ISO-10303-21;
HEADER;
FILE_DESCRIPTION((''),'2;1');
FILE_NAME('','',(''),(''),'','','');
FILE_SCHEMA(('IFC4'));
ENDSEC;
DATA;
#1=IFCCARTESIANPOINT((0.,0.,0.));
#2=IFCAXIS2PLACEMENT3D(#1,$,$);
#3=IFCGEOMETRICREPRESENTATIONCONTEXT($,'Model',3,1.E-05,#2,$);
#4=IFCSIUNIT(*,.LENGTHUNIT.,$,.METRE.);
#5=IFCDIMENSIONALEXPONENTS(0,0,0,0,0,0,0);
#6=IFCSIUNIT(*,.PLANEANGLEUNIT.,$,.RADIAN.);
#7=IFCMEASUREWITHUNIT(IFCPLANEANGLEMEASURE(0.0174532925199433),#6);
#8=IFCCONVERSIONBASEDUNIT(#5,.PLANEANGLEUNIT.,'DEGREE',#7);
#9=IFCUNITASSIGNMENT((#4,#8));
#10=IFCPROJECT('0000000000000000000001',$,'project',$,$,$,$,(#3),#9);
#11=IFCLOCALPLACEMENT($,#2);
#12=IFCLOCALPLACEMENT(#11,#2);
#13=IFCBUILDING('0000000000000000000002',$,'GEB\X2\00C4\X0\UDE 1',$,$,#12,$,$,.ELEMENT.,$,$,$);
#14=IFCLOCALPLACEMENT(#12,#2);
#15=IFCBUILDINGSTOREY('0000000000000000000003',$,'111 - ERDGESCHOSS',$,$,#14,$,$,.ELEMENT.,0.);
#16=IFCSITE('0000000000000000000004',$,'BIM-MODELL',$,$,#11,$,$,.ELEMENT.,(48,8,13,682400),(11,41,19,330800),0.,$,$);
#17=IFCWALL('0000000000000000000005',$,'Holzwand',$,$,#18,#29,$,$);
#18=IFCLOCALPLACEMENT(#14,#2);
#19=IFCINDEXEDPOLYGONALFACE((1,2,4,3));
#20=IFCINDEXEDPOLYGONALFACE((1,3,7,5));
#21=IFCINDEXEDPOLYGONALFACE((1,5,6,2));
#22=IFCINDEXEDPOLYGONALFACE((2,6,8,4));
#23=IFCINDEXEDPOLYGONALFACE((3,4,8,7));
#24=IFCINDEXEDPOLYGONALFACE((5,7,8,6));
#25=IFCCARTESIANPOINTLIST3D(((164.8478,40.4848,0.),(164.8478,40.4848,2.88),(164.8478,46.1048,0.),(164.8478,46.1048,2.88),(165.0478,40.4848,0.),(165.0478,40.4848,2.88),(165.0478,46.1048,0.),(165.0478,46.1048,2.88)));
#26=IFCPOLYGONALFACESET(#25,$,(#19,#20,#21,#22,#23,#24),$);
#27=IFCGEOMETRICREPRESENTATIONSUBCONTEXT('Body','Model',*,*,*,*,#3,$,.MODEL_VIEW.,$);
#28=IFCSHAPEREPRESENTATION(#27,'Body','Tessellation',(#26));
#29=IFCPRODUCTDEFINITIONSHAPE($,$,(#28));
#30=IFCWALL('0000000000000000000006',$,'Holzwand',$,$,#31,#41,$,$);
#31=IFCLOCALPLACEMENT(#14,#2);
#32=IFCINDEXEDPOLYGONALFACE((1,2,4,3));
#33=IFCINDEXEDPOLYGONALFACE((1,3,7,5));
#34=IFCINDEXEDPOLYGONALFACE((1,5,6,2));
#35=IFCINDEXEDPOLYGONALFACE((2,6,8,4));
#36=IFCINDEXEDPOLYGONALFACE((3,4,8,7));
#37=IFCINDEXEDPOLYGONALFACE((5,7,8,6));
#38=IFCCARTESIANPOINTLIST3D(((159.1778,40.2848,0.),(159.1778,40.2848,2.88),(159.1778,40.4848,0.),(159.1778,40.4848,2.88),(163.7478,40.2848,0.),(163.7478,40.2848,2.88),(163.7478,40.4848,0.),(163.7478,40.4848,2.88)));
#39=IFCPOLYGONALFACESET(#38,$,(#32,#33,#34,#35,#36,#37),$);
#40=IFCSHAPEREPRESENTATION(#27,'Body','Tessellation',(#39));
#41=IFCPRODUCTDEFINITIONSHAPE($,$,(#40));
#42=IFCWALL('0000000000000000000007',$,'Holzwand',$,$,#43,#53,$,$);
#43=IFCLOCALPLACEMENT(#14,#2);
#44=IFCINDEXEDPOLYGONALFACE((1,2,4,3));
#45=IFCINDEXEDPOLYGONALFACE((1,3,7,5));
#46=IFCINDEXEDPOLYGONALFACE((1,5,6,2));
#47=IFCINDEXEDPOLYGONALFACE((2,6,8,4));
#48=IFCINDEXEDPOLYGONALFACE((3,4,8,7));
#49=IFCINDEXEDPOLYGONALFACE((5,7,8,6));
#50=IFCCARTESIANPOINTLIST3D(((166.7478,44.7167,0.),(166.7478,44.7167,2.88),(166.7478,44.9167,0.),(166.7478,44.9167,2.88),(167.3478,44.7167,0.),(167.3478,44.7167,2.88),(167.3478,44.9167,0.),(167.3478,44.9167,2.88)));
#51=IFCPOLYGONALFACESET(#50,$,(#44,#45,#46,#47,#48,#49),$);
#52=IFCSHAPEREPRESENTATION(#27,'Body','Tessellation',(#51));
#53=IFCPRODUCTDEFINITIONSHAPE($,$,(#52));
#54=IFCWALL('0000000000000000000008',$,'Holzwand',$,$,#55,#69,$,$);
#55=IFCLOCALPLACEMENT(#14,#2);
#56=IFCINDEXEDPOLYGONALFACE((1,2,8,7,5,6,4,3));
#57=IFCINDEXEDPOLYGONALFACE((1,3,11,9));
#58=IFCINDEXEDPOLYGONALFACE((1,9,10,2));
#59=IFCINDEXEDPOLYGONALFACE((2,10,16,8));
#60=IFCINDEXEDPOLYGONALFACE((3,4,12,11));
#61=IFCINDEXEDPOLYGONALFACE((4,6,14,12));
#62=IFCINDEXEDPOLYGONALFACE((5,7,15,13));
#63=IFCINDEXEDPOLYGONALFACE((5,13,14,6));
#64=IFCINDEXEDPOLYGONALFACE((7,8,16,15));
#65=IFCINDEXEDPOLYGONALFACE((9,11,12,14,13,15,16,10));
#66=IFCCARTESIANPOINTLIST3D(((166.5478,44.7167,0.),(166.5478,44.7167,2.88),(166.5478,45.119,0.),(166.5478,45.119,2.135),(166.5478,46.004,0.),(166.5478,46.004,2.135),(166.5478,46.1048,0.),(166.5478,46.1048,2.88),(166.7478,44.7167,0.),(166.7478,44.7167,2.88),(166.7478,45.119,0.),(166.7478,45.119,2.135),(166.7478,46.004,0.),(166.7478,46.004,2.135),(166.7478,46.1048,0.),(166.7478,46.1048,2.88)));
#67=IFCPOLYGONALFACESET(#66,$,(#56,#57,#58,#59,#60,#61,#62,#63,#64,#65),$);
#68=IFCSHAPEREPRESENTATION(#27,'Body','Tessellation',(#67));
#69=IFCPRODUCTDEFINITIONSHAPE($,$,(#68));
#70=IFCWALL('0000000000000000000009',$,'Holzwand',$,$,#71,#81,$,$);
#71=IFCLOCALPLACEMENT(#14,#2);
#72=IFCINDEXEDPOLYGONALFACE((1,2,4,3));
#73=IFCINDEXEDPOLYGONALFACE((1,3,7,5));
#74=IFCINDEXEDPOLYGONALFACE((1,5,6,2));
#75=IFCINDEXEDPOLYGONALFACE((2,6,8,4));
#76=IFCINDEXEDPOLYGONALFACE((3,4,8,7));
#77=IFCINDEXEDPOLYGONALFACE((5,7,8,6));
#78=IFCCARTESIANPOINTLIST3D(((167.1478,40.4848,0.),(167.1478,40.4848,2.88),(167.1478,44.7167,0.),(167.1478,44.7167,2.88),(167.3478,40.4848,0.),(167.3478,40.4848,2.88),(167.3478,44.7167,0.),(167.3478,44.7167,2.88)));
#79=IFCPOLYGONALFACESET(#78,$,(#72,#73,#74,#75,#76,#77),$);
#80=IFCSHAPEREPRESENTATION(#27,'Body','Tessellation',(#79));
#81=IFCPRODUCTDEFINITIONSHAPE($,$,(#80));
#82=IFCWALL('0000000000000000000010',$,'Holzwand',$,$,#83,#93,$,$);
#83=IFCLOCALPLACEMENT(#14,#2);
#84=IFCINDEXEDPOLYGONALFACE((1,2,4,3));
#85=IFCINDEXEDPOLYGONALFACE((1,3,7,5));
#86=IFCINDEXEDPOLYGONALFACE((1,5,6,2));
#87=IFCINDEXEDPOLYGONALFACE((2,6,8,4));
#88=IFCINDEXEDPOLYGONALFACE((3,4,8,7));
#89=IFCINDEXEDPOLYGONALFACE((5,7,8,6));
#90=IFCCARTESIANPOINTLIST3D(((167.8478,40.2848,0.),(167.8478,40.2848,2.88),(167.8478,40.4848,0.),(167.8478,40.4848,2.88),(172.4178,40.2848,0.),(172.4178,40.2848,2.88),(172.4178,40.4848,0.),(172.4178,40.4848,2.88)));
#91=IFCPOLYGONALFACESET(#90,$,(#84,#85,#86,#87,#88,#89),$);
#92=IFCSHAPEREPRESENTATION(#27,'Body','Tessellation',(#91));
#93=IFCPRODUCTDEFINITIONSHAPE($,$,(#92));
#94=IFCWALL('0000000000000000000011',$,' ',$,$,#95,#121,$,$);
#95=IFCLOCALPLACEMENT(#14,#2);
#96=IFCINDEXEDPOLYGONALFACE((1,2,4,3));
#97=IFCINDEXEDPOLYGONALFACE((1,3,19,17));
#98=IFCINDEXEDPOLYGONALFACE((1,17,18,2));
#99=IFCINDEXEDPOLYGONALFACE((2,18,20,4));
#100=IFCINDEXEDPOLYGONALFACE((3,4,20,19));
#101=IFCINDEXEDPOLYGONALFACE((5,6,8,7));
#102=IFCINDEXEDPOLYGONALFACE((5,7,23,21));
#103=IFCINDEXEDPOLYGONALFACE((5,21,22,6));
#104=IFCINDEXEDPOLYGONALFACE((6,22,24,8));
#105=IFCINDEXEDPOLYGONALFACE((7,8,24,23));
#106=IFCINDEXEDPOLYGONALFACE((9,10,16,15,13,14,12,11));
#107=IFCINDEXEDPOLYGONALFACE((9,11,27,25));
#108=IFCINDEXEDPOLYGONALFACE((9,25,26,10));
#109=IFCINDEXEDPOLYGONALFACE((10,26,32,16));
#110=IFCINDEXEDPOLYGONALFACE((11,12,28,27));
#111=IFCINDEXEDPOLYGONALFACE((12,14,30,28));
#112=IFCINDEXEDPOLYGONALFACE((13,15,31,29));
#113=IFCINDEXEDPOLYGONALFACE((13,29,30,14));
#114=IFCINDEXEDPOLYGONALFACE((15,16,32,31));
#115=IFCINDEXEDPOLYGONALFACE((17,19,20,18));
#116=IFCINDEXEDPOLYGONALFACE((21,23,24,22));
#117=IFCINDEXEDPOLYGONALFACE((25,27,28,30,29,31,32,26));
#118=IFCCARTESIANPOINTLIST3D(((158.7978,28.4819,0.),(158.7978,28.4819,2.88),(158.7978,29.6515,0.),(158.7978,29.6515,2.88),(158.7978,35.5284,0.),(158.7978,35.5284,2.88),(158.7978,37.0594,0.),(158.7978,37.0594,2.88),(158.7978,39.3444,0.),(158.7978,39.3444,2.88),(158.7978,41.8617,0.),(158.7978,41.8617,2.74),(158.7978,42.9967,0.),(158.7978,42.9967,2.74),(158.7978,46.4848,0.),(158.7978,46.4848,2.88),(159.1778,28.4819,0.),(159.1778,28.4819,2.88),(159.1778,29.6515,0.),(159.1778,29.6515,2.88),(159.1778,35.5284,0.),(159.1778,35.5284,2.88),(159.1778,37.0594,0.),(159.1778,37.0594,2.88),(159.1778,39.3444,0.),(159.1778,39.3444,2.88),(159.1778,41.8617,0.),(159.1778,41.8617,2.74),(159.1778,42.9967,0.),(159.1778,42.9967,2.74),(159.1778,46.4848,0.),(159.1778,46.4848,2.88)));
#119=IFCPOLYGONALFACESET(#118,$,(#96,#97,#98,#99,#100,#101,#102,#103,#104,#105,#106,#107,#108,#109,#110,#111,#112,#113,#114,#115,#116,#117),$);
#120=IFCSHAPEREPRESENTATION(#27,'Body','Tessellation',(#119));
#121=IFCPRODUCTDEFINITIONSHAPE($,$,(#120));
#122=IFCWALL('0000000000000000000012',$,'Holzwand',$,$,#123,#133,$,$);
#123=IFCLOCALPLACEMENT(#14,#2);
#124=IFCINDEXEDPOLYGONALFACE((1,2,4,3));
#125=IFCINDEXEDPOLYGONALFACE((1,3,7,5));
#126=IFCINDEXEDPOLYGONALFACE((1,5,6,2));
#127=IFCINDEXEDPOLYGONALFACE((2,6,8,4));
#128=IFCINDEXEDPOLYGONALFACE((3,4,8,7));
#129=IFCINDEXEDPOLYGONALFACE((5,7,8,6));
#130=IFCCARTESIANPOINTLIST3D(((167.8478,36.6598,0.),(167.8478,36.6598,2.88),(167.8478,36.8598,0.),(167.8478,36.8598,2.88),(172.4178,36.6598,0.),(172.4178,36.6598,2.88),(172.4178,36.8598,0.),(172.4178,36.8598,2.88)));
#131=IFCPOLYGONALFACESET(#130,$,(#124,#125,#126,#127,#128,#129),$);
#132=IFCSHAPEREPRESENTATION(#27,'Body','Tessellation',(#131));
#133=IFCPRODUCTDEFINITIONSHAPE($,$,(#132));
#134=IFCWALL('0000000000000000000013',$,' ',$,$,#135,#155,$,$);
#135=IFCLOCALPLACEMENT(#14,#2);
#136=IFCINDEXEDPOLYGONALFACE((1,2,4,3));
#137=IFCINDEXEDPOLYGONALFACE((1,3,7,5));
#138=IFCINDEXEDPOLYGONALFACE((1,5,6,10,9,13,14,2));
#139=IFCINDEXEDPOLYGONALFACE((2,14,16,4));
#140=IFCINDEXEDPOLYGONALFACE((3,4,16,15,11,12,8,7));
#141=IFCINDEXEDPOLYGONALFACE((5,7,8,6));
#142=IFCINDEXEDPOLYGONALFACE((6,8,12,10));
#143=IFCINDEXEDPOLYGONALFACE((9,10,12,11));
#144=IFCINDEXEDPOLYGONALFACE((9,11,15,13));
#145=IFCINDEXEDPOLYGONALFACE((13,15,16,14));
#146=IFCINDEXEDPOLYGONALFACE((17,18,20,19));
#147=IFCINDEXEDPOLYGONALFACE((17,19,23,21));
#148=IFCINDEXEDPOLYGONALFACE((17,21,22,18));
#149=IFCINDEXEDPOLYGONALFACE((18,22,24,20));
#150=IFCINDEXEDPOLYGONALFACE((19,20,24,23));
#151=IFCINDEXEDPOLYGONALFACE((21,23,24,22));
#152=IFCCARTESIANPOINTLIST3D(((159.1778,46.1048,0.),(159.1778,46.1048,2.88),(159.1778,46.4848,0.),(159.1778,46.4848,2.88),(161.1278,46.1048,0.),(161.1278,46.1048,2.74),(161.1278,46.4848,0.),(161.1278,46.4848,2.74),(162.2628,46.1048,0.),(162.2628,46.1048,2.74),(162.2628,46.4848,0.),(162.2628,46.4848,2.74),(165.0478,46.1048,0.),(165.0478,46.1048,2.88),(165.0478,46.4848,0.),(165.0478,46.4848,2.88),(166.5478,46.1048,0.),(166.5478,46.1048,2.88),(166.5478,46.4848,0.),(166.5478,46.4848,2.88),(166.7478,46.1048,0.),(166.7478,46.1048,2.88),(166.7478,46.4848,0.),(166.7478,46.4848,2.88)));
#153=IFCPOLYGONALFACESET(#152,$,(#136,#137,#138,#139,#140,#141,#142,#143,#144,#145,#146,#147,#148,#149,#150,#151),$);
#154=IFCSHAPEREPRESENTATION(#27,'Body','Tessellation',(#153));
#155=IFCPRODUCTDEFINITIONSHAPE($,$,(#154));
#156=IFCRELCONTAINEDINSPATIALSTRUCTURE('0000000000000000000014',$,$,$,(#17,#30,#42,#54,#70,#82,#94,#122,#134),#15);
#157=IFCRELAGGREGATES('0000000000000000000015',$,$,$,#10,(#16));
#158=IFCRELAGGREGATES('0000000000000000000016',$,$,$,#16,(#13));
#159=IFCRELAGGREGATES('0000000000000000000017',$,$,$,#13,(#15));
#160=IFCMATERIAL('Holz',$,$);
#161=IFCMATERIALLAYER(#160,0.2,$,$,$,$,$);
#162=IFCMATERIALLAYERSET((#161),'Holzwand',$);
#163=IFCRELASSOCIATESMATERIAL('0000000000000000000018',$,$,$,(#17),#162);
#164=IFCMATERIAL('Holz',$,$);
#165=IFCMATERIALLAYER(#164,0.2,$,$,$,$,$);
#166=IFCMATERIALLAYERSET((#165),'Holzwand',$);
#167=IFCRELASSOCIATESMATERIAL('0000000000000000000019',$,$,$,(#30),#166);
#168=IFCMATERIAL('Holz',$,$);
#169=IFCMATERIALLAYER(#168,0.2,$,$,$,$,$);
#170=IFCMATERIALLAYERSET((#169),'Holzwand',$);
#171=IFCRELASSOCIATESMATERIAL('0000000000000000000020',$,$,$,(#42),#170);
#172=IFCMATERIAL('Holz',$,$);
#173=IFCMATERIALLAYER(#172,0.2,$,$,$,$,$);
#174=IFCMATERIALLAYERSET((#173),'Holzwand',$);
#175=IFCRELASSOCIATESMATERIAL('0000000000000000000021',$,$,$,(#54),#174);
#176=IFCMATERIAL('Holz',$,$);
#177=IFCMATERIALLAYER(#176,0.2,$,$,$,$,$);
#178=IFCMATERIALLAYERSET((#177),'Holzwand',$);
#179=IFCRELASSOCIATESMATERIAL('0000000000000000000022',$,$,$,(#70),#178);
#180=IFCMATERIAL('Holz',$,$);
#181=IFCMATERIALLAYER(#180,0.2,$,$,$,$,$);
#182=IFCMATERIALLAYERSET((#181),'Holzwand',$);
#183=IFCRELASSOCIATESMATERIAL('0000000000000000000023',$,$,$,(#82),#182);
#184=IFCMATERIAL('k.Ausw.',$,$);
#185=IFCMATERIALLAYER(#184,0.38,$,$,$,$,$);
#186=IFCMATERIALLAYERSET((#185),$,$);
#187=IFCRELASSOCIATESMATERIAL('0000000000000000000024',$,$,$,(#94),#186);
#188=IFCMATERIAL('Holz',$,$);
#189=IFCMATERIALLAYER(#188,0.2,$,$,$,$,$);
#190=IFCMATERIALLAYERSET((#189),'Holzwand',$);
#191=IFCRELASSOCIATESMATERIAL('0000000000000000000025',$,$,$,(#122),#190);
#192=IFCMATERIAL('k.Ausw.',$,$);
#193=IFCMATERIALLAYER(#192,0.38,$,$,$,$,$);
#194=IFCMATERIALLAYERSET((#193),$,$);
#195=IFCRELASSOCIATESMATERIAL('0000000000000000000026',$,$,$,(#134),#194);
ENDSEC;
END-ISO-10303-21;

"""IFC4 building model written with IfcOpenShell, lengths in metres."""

from ifc_helpers import new_model, entity, si_unit, converted_unit, frame, frame_2d, origin, origin_with_axes, place, context, subcontext, project, spatial, polyline, rectangle, outline, extrude, material, layer, layer_set, layer_usage, element, save


model = new_model("IFC4")

# Units and contexts
model_context = context("Model", 3, precision=1e-05, world=origin())
body_context = subcontext(model_context, "Body", "Model", "MODEL_VIEW")
ifc_project = project(units=[si_unit("LENGTHUNIT", "METRE"), converted_unit("PLANEANGLEUNIT", "DEGREE", entity("IfcPlaneAngleMeasure", 0.0174532925199433), si_unit("PLANEANGLEUNIT", "RADIAN"), dimensions=[0, 0, 0, 0, 0, 0, 0])], contexts=[model_context])

# Site, building, storey
site_placement = place(None, origin())
site = spatial("IfcSite", under=ifc_project, at=site_placement, Name="BIM-MODELL", CompositionType="ELEMENT", RefLatitude=(48, 8, 13, 682400), RefLongitude=(11, 41, 19, 330800), RefElevation=0.0)
building_placement = place(site_placement, origin())
building = spatial("IfcBuilding", under=site, at=building_placement, Name="GEBÄUDE 1", CompositionType="ELEMENT")
storey_placement = place(building_placement, origin())
storey = spatial("IfcBuildingStorey", under=building, at=storey_placement, Name="111 - ERDGESCHOSS", CompositionType="ELEMENT", Elevation=0.0)

# Walls
ifc_material_1 = material(Name="Holz")
ifc_layer_1 = layer(ifc_material_1, 0.2)
ifc_layer_set_1 = layer_set([ifc_layer_1], Name="Holzwand")
ifc_layer_usage_1 = layer_usage(ifc_layer_set_1, "AXIS2", "POSITIVE", 0.0)
wall_1_placement = place(storey_placement, frame((164.8478, 46.1048, 0.0), z_axis=(0.0, 0.0, 1.0), x_axis=(0.0, -1.0, 0.0)))
element("IfcWall", 1, at=wall_1_placement, inside=storey, material=ifc_layer_usage_1, Name="Holzwand", context=body_context, shape_type="SweptSolid", body=[
    extrude(rectangle(XDim=5.62, YDim=0.2, at=frame_2d((2.81, 0.1), x_axis=(1.0, 0.0))), origin_with_axes(), (0.0, 0.0, 1.0), 2.88),
])
ifc_material_2 = material(Name="Holz")
ifc_layer_2 = layer(ifc_material_2, 0.2)
ifc_layer_set_2 = layer_set([ifc_layer_2], Name="Holzwand")
ifc_layer_usage_2 = layer_usage(ifc_layer_set_2, "AXIS2", "POSITIVE", 0.0)
wall_2_placement = place(storey_placement, frame((163.7478, 40.4848, 0.0), z_axis=(0.0, 0.0, 1.0), x_axis=(-1.0, 0.0, 0.0)))
element("IfcWall", 2, at=wall_2_placement, inside=storey, material=ifc_layer_usage_2, Name="Holzwand", context=body_context, shape_type="SweptSolid", body=[
    extrude(rectangle(XDim=4.57, YDim=0.2, at=frame_2d((2.285, 0.1), x_axis=(1.0, 0.0))), origin_with_axes(), (0.0, 0.0, 1.0), 2.88),
])
ifc_material_3 = material(Name="Holz")
ifc_layer_3 = layer(ifc_material_3, 0.2)
ifc_layer_set_3 = layer_set([ifc_layer_3], Name="Holzwand")
ifc_layer_usage_3 = layer_usage(ifc_layer_set_3, "AXIS2", "POSITIVE", 0.0)
wall_3_placement = place(storey_placement, frame((166.7478, 44.7167, 0.0)))
element("IfcWall", 3, at=wall_3_placement, inside=storey, material=ifc_layer_usage_3, Name="Holzwand", context=body_context, shape_type="SweptSolid", body=[
    extrude(rectangle(XDim=0.6, YDim=0.2, at=frame_2d((0.3, 0.1), x_axis=(1.0, 0.0))), origin_with_axes(), (0.0, 0.0, 1.0), 2.88),
])

# Wall, opening
ifc_material_4 = material(Name="Holz")
ifc_layer_4 = layer(ifc_material_4, 0.2)
ifc_layer_set_4 = layer_set([ifc_layer_4], Name="Holzwand")
ifc_layer_usage_4 = layer_usage(ifc_layer_set_4, "AXIS2", "POSITIVE", 0.0)
wall_4_placement = place(storey_placement, frame((166.5478, 46.1048, 0.0), z_axis=(0.0, 0.0, 1.0), x_axis=(0.0, -1.0, 0.0)))
wall_4 = element("IfcWall", 4, at=wall_4_placement, inside=storey, material=ifc_layer_usage_4, Name="Holzwand", context=body_context, shape_type="SweptSolid", body=[
    extrude(rectangle(XDim=1.3881, YDim=0.2, at=frame_2d((0.6941, 0.1), x_axis=(1.0, 0.0))), origin_with_axes(), (0.0, 0.0, 1.0), 2.88),
])
opening_1_placement = place(wall_4_placement, frame((0.9858, 0.2, 0.0), z_axis=(0.0, -1.0, 0.0), x_axis=(0.0, 0.0, 1.0)))
element("IfcOpeningElement", 5, at=opening_1_placement, cuts=wall_4, ObjectType="Opening", context=body_context, shape_type="SweptSolid", body=[
    extrude(outline(polyline([(0.0, 0.885), (2.135, 0.885), (2.135, 0.0), (0.0, 0.0), (0.0, 0.885)])), origin_with_axes(), (0.0, 0.0, 1.0), 0.2),
])

# Walls
ifc_material_5 = material(Name="Holz")
ifc_layer_5 = layer(ifc_material_5, 0.2)
ifc_layer_set_5 = layer_set([ifc_layer_5], Name="Holzwand")
ifc_layer_usage_5 = layer_usage(ifc_layer_set_5, "AXIS2", "POSITIVE", 0.0)
wall_5_placement = place(storey_placement, frame((167.1478, 44.7167, 0.0), z_axis=(0.0, 0.0, 1.0), x_axis=(0.0, -1.0, 0.0)))
element("IfcWall", 6, at=wall_5_placement, inside=storey, material=ifc_layer_usage_5, Name="Holzwand", context=body_context, shape_type="SweptSolid", body=[
    extrude(rectangle(XDim=4.2319, YDim=0.2, at=frame_2d((2.1159, 0.1), x_axis=(1.0, 0.0))), origin_with_axes(), (0.0, 0.0, 1.0), 2.88),
])
ifc_material_6 = material(Name="Holz")
ifc_layer_6 = layer(ifc_material_6, 0.2)
ifc_layer_set_6 = layer_set([ifc_layer_6], Name="Holzwand")
ifc_layer_usage_6 = layer_usage(ifc_layer_set_6, "AXIS2", "POSITIVE", 0.0)
wall_6_placement = place(storey_placement, frame((172.4178, 40.4848, 0.0), z_axis=(0.0, 0.0, 1.0), x_axis=(-1.0, 0.0, 0.0)))
element("IfcWall", 7, at=wall_6_placement, inside=storey, material=ifc_layer_usage_6, Name="Holzwand", context=body_context, shape_type="SweptSolid", body=[
    extrude(rectangle(XDim=4.57, YDim=0.2, at=frame_2d((2.285, 0.1), x_axis=(1.0, 0.0))), origin_with_axes(), (0.0, 0.0, 1.0), 2.88),
])

# Wall, openings
ifc_material_7 = material(Name="k.Ausw.")
ifc_layer_7 = layer(ifc_material_7, 0.38)
ifc_layer_set_7 = layer_set([ifc_layer_7])
ifc_layer_usage_7 = layer_usage(ifc_layer_set_7, "AXIS2", "POSITIVE", 0.0)
wall_7_placement = place(storey_placement, frame((158.7978, 46.4848, 0.0), z_axis=(0.0, 0.0, 1.0), x_axis=(0.0, -1.0, 0.0)))
wall_7 = element("IfcWall", 8, at=wall_7_placement, inside=storey, material=ifc_layer_usage_7, Name=" ", context=body_context, shape_type="SweptSolid", body=[
    extrude(rectangle(XDim=18.0029, YDim=0.38, at=frame_2d((9.0014, 0.19), x_axis=(1.0, 0.0))), origin_with_axes(), (0.0, 0.0, 1.0), 2.88),
])
opening_2_placement = place(wall_7_placement, frame((8.2904, 0.0, 0.0), z_axis=(0.0, 1.0, 0.0), x_axis=(0.0, 0.0, 1.0)))
element("IfcOpeningElement", 9, at=opening_2_placement, cuts=wall_7, ObjectType="Opening", context=body_context, shape_type="SweptSolid", body=[
    extrude(outline(polyline([(0.0, 1.135), (2.88, 1.135), (2.88, 0.0), (0.0, 0.0), (0.0, 1.135)])), origin_with_axes(), (0.0, 0.0, 1.0), 0.38),
])
opening_3_placement = place(wall_7_placement, frame((10.9564, 0.0, 0.0), z_axis=(0.0, 1.0, 0.0), x_axis=(0.0, 0.0, 1.0)))
element("IfcOpeningElement", 10, at=opening_3_placement, cuts=wall_7, ObjectType="Opening", context=body_context, shape_type="SweptSolid", body=[
    extrude(outline(polyline([(0.0, 1.135), (2.88, 1.135), (2.88, 0.0), (0.0, 0.0), (0.0, 1.135)])), origin_with_axes(), (0.0, 0.0, 1.0), 0.38),
])
opening_4_placement = place(wall_7_placement, frame((15.6983, 0.0, 0.0), z_axis=(0.0, 1.0, 0.0), x_axis=(0.0, 0.0, 1.0)))
element("IfcOpeningElement", 11, at=opening_4_placement, cuts=wall_7, ObjectType="Opening", context=body_context, shape_type="SweptSolid", body=[
    extrude(outline(polyline([(0.0, 1.135), (2.88, 1.135), (2.88, 0.0), (0.0, 0.0), (0.0, 1.135)])), origin_with_axes(), (0.0, 0.0, 1.0), 0.38),
])
opening_5_placement = place(wall_7_placement, frame((12.0914, 0.0, 0.0), z_axis=(0.0, 1.0, 0.0), x_axis=(0.0, 0.0, 1.0)))
element("IfcOpeningElement", 12, at=opening_5_placement, cuts=wall_7, ObjectType="Opening", context=body_context, shape_type="SweptSolid", body=[
    extrude(outline(polyline([(0.0, 3.608), (2.88, 3.608), (2.88, 0.0), (0.0, 0.0), (0.0, 3.608)])), origin_with_axes(), (0.0, 0.0, 1.0), 0.38),
])
opening_6_placement = place(wall_7_placement, frame((7.1404, 0.0, 0.0), z_axis=(0.0, 1.0, 0.0), x_axis=(0.0, 0.0, 1.0)))
element("IfcOpeningElement", 13, at=opening_6_placement, cuts=wall_7, ObjectType="Opening", context=body_context, shape_type="SweptSolid", body=[
    extrude(outline(polyline([(0.0, 1.15), (2.88, 1.15), (2.88, 0.0), (0.0, 0.0), (0.0, 1.15)])), origin_with_axes(), (0.0, 0.0, 1.0), 0.38),
])
opening_7_placement = place(wall_7_placement, frame((3.4881, 0.0, 0.0), z_axis=(0.0, 1.0, 0.0), x_axis=(0.0, 0.0, 1.0)))
element("IfcOpeningElement", 14, at=opening_7_placement, cuts=wall_7, ObjectType="Opening", context=body_context, shape_type="SweptSolid", body=[
    extrude(outline(polyline([(0.0, 1.135), (2.74, 1.135), (2.74, 0.0), (0.0, 0.0), (0.0, 1.135)])), origin_with_axes(), (0.0, 0.0, 1.0), 0.38),
])

# Wall
ifc_material_8 = material(Name="Holz")
ifc_layer_8 = layer(ifc_material_8, 0.2)
ifc_layer_set_8 = layer_set([ifc_layer_8], Name="Holzwand")
ifc_layer_usage_8 = layer_usage(ifc_layer_set_8, "AXIS2", "POSITIVE", 0.0)
wall_8_placement = place(storey_placement, frame((167.8478, 36.6598, 0.0)))
element("IfcWall", 15, at=wall_8_placement, inside=storey, material=ifc_layer_usage_8, Name="Holzwand", context=body_context, shape_type="SweptSolid", body=[
    extrude(rectangle(XDim=4.57, YDim=0.2, at=frame_2d((2.285, 0.1), x_axis=(1.0, 0.0))), origin_with_axes(), (0.0, 0.0, 1.0), 2.88),
])

# Wall, openings
ifc_material_9 = material(Name="k.Ausw.")
ifc_layer_9 = layer(ifc_material_9, 0.38)
ifc_layer_set_9 = layer_set([ifc_layer_9])
ifc_layer_usage_9 = layer_usage(ifc_layer_set_9, "AXIS2", "POSITIVE", 0.0)
wall_9_placement = place(storey_placement, frame((166.7478, 46.4848, 0.0), z_axis=(0.0, 0.0, 1.0), x_axis=(-1.0, 0.0, 0.0)))
wall_9 = element("IfcWall", 16, at=wall_9_placement, inside=storey, material=ifc_layer_usage_9, Name=" ", context=body_context, shape_type="SweptSolid", body=[
    extrude(rectangle(XDim=7.57, YDim=0.38, at=frame_2d((3.785, 0.19), x_axis=(1.0, 0.0))), origin_with_axes(), (0.0, 0.0, 1.0), 2.88),
])
opening_8_placement = place(wall_9_placement, frame((5.62, 0.38, 0.0), z_axis=(0.0, -1.0, 0.0), x_axis=(0.0, 0.0, 1.0)))
element("IfcOpeningElement", 17, at=opening_8_placement, cuts=wall_9, ObjectType="Opening", context=body_context, shape_type="SweptSolid", body=[
    extrude(outline(polyline([(0.0, 1.135), (2.74, 1.135), (2.74, 0.0), (0.0, 0.0), (0.0, 1.135)])), origin_with_axes(), (0.0, 0.0, 1.0), 0.38),
])
opening_9_placement = place(wall_9_placement, frame((0.2, 0.0, -0.15), z_axis=(0.0, 1.0, 0.0), x_axis=(0.0, 0.0, 1.0)))
element("IfcOpeningElement", 18, at=opening_9_placement, cuts=wall_9, ObjectType="Opening", context=body_context, shape_type="SweptSolid", body=[
    extrude(outline(polyline([(0.0, 1.5), (3.03, 1.5), (3.03, 0.0), (0.0, 0.0), (0.0, 1.5)])), origin_with_axes(), (0.0, 0.0, 1.0), 0.38),
])

save(model, "model.ifc")
